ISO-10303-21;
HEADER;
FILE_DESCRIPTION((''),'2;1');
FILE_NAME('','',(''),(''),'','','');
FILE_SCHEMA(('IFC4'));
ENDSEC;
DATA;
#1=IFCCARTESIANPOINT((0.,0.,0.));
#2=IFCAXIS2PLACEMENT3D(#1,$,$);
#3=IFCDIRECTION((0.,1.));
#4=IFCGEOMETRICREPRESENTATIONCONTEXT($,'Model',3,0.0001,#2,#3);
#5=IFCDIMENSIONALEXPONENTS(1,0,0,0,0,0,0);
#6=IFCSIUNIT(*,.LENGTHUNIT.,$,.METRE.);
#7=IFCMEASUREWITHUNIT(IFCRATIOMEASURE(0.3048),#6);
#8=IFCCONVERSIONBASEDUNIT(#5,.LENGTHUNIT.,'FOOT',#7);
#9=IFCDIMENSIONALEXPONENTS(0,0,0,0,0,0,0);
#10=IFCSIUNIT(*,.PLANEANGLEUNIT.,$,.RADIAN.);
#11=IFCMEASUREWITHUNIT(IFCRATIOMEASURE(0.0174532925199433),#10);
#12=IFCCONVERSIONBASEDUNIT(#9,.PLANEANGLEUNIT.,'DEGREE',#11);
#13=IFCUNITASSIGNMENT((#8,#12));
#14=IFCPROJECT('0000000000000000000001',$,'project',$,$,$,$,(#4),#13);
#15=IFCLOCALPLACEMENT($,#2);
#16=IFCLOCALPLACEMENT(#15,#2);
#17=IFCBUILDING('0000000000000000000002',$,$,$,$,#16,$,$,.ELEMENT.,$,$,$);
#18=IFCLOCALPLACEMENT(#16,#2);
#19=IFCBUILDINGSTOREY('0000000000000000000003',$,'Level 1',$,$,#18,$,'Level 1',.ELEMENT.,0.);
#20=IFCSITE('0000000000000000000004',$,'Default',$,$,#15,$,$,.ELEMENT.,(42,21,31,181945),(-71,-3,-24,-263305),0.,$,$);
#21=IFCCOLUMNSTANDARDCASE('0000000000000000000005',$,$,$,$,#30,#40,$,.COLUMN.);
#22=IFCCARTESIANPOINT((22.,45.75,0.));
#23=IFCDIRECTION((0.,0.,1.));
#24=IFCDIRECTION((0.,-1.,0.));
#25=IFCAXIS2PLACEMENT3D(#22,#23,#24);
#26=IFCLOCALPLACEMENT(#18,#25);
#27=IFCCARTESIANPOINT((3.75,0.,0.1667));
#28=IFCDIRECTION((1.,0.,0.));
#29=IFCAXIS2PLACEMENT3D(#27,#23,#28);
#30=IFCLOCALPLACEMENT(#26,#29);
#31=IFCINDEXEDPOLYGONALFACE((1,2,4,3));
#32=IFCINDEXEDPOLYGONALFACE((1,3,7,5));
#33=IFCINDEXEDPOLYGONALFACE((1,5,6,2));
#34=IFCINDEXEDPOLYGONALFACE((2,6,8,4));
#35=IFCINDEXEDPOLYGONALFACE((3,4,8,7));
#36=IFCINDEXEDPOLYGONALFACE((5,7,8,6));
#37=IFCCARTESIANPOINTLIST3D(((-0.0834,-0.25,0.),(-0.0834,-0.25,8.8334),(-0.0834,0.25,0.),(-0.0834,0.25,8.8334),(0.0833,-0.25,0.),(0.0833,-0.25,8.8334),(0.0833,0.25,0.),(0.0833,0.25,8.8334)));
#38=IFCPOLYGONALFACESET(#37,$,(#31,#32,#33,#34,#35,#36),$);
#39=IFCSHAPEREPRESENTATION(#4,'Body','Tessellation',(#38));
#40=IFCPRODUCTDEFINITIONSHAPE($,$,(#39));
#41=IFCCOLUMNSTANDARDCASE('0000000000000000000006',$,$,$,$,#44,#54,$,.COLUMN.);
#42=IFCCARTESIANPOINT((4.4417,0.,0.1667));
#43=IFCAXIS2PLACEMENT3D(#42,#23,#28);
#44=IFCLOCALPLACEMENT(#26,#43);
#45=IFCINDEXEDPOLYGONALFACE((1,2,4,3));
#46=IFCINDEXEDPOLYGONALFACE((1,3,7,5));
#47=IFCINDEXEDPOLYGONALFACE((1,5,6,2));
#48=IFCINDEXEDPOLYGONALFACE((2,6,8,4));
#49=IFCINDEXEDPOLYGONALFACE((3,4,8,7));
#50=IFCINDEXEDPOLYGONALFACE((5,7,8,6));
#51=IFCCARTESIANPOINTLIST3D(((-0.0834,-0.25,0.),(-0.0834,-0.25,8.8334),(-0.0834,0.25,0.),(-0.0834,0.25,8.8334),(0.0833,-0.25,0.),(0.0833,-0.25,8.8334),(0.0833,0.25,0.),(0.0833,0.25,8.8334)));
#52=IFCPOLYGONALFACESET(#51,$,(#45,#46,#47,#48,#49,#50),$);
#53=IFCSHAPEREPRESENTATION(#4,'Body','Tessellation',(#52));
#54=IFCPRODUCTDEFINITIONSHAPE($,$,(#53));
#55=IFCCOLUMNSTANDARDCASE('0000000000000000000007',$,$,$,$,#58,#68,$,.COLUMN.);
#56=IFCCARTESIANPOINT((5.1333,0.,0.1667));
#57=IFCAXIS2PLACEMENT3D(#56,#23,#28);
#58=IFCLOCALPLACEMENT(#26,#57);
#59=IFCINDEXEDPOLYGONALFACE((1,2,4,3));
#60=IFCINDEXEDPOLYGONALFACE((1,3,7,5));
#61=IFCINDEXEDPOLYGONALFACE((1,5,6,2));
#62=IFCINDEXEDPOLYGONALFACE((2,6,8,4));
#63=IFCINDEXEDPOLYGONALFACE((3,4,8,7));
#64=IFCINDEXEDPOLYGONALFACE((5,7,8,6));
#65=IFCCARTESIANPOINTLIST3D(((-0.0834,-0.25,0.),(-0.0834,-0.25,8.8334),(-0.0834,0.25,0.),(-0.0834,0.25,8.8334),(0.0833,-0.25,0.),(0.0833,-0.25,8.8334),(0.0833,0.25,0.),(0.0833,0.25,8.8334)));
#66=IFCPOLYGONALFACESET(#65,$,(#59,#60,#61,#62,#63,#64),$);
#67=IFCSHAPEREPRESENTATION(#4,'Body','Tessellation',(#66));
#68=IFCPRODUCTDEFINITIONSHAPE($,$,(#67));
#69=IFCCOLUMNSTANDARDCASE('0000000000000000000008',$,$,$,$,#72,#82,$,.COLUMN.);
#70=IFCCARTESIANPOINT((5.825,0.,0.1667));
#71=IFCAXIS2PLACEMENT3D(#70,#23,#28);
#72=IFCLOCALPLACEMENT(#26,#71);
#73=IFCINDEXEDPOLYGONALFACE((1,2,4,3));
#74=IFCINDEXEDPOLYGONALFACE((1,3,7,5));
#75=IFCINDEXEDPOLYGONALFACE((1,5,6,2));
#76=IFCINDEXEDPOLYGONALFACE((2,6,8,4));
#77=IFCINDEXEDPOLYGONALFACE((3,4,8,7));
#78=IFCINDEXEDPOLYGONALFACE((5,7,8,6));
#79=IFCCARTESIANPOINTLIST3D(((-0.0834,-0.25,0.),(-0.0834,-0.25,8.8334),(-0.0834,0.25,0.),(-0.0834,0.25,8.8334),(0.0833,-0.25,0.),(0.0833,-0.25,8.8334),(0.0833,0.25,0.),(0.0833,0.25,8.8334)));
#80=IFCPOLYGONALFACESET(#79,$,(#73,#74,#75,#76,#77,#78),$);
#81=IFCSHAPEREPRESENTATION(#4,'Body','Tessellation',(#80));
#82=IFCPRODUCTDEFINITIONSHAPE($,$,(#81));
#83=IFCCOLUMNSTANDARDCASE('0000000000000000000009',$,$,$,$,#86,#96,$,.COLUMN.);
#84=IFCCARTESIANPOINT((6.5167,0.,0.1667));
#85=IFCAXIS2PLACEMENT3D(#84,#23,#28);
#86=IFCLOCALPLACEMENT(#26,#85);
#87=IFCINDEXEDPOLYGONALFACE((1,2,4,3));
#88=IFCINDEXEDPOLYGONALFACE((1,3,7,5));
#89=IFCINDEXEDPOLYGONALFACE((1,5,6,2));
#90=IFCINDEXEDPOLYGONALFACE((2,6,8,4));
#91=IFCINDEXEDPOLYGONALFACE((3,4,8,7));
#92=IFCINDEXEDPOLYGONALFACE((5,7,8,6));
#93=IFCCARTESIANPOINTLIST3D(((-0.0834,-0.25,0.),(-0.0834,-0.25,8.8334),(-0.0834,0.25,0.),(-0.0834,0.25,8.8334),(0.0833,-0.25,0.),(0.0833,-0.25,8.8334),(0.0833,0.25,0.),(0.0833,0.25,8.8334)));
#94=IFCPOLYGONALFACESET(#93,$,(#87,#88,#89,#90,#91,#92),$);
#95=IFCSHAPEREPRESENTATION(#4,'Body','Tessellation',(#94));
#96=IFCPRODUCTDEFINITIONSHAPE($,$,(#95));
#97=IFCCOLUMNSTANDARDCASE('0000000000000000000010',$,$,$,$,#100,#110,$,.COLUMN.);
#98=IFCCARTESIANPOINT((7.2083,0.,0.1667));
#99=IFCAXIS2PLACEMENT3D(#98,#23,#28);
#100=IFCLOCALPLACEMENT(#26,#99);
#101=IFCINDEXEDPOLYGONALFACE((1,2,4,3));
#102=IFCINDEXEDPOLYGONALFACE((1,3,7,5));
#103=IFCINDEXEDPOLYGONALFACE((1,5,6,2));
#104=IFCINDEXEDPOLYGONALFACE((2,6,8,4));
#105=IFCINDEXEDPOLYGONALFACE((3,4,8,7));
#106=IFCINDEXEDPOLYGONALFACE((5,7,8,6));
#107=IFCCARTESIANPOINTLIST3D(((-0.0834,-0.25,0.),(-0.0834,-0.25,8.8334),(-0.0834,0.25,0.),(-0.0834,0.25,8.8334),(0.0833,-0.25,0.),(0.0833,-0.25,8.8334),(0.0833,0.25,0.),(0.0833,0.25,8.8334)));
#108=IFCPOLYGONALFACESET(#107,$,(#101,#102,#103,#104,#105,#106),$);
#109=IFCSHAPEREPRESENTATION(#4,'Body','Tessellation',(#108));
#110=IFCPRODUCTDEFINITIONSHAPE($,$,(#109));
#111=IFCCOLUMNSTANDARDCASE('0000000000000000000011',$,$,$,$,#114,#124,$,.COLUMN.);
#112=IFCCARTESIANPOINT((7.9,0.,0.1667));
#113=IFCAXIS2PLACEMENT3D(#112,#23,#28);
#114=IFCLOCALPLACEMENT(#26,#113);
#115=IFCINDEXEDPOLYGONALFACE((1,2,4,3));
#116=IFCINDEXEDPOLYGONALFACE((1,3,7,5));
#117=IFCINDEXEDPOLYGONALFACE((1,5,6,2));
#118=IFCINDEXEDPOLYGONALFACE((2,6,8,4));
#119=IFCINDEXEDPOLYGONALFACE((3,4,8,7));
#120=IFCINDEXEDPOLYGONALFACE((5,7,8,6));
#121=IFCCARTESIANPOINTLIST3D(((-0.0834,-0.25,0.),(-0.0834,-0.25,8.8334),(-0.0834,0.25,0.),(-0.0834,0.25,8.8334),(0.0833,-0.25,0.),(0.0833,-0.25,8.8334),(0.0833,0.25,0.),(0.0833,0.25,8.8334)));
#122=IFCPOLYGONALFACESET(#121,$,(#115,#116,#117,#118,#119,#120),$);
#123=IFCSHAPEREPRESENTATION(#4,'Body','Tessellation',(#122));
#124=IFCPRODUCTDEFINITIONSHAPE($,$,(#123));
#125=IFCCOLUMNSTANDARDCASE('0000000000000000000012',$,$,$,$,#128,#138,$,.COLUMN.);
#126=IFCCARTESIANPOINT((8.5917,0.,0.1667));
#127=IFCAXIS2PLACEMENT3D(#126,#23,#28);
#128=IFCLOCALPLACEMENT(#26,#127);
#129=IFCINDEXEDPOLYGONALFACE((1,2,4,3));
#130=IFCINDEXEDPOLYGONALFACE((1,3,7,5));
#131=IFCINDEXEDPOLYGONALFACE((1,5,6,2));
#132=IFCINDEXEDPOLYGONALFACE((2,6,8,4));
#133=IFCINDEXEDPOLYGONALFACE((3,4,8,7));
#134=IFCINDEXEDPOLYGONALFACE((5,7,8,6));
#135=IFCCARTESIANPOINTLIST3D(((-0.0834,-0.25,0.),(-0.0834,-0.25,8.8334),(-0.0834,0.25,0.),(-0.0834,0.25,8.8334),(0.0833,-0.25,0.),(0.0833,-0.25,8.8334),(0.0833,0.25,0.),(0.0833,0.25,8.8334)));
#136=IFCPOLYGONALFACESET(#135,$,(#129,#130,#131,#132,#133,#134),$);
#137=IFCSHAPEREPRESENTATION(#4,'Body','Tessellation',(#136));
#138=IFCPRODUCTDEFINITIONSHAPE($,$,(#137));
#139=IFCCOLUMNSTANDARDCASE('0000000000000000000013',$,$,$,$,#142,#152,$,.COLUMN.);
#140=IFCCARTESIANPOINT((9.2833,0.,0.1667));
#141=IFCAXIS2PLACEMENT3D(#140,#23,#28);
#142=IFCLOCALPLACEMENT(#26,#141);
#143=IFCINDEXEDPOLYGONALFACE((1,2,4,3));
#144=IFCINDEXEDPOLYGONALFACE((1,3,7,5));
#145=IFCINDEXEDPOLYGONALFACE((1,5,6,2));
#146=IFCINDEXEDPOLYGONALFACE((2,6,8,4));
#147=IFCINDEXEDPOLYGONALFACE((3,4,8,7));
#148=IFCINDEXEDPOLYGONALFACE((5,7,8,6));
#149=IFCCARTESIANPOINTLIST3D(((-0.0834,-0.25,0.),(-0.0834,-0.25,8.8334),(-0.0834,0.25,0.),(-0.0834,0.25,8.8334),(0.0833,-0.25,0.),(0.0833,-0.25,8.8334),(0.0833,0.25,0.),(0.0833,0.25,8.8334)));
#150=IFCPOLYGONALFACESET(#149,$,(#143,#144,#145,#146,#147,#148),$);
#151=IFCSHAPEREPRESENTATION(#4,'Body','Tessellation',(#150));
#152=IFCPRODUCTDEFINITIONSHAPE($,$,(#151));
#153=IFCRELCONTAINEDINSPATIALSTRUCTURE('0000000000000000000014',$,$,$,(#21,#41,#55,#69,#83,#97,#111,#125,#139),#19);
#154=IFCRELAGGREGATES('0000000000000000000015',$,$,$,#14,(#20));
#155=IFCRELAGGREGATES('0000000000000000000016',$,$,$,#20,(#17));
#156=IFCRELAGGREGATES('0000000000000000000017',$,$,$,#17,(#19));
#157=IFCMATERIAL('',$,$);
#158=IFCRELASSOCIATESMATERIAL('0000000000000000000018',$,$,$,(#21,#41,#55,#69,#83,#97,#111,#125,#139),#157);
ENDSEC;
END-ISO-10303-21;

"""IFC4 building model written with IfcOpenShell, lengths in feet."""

from ifc_helpers import new_model, entity, si_unit, converted_unit, direction, frame, origin, place, context, project, spatial, rectangle, extrude, material, element, save


model = new_model("IFC4")

# Units and contexts
model_context = context("Model", 3, precision=0.0001, world=origin(), true_north=direction((0.0, 1.0)))
ifc_project = project(units=[converted_unit("LENGTHUNIT", "FOOT", entity("IfcRatioMeasure", 0.3048), si_unit("LENGTHUNIT", "METRE"), dimensions=[1, 0, 0, 0, 0, 0, 0]), converted_unit("PLANEANGLEUNIT", "DEGREE", entity("IfcRatioMeasure", 0.0174532925199433), si_unit("PLANEANGLEUNIT", "RADIAN"), dimensions=[0, 0, 0, 0, 0, 0, 0])], contexts=[model_context])

# Site, building, storey
site_placement = place(None, origin())
site = spatial("IfcSite", under=ifc_project, at=site_placement, Name="Default", CompositionType="ELEMENT", RefLatitude=(42, 21, 31, 181945), RefLongitude=(-71, -3, -24, -263305), RefElevation=0.0)
building_placement = place(site_placement, origin())
building = spatial("IfcBuilding", under=site, at=building_placement, CompositionType="ELEMENT")
storey_placement = place(building_placement, origin())
storey = spatial("IfcBuildingStorey", under=building, at=storey_placement, Name="Level 1", LongName="Level 1", CompositionType="ELEMENT", Elevation=0.0)

# Columns
ifc_material_1 = material(Name="")
placement_1 = place(storey_placement, frame((22.0, 45.75, 0.0), z_axis=(0.0, 0.0, 1.0), x_axis=(0.0, -1.0, 0.0)))
for number, where, z_axis, x_axis in (
    (1, (3.75, 0.0, 0.1667), (0.0, 0.0, 1.0), (1.0, 0.0, 0.0)),
    (2, (4.4417, 0.0, 0.1667), (0.0, 0.0, 1.0), (1.0, 0.0, 0.0)),
    (3, (5.1333, 0.0, 0.1667), (0.0, 0.0, 1.0), (1.0, 0.0, 0.0)),
    (4, (5.825, 0.0, 0.1667), (0.0, 0.0, 1.0), (1.0, 0.0, 0.0)),
    (5, (6.5167, 0.0, 0.1667), (0.0, 0.0, 1.0), (1.0, 0.0, 0.0)),
    (6, (7.2083, 0.0, 0.1667), (0.0, 0.0, 1.0), (1.0, 0.0, 0.0)),
    (7, (7.9, 0.0, 0.1667), (0.0, 0.0, 1.0), (1.0, 0.0, 0.0)),
    (8, (8.5917, 0.0, 0.1667), (0.0, 0.0, 1.0), (1.0, 0.0, 0.0)),
    (9, (9.2833, 0.0, 0.1667), (0.0, 0.0, 1.0), (1.0, 0.0, 0.0)),
):
    element("IfcColumnStandardCase", number, at=place(placement_1, frame(where, z_axis=z_axis, x_axis=x_axis)), inside=storey, material=ifc_material_1, PredefinedType="COLUMN", context=model_context, shape_type="SweptSolid", body=[
        extrude(rectangle(XDim=0.1667, YDim=0.5), origin(), (0.0, 0.0, 1.0), 8.8334),
    ])

save(model, "model.ifc")
